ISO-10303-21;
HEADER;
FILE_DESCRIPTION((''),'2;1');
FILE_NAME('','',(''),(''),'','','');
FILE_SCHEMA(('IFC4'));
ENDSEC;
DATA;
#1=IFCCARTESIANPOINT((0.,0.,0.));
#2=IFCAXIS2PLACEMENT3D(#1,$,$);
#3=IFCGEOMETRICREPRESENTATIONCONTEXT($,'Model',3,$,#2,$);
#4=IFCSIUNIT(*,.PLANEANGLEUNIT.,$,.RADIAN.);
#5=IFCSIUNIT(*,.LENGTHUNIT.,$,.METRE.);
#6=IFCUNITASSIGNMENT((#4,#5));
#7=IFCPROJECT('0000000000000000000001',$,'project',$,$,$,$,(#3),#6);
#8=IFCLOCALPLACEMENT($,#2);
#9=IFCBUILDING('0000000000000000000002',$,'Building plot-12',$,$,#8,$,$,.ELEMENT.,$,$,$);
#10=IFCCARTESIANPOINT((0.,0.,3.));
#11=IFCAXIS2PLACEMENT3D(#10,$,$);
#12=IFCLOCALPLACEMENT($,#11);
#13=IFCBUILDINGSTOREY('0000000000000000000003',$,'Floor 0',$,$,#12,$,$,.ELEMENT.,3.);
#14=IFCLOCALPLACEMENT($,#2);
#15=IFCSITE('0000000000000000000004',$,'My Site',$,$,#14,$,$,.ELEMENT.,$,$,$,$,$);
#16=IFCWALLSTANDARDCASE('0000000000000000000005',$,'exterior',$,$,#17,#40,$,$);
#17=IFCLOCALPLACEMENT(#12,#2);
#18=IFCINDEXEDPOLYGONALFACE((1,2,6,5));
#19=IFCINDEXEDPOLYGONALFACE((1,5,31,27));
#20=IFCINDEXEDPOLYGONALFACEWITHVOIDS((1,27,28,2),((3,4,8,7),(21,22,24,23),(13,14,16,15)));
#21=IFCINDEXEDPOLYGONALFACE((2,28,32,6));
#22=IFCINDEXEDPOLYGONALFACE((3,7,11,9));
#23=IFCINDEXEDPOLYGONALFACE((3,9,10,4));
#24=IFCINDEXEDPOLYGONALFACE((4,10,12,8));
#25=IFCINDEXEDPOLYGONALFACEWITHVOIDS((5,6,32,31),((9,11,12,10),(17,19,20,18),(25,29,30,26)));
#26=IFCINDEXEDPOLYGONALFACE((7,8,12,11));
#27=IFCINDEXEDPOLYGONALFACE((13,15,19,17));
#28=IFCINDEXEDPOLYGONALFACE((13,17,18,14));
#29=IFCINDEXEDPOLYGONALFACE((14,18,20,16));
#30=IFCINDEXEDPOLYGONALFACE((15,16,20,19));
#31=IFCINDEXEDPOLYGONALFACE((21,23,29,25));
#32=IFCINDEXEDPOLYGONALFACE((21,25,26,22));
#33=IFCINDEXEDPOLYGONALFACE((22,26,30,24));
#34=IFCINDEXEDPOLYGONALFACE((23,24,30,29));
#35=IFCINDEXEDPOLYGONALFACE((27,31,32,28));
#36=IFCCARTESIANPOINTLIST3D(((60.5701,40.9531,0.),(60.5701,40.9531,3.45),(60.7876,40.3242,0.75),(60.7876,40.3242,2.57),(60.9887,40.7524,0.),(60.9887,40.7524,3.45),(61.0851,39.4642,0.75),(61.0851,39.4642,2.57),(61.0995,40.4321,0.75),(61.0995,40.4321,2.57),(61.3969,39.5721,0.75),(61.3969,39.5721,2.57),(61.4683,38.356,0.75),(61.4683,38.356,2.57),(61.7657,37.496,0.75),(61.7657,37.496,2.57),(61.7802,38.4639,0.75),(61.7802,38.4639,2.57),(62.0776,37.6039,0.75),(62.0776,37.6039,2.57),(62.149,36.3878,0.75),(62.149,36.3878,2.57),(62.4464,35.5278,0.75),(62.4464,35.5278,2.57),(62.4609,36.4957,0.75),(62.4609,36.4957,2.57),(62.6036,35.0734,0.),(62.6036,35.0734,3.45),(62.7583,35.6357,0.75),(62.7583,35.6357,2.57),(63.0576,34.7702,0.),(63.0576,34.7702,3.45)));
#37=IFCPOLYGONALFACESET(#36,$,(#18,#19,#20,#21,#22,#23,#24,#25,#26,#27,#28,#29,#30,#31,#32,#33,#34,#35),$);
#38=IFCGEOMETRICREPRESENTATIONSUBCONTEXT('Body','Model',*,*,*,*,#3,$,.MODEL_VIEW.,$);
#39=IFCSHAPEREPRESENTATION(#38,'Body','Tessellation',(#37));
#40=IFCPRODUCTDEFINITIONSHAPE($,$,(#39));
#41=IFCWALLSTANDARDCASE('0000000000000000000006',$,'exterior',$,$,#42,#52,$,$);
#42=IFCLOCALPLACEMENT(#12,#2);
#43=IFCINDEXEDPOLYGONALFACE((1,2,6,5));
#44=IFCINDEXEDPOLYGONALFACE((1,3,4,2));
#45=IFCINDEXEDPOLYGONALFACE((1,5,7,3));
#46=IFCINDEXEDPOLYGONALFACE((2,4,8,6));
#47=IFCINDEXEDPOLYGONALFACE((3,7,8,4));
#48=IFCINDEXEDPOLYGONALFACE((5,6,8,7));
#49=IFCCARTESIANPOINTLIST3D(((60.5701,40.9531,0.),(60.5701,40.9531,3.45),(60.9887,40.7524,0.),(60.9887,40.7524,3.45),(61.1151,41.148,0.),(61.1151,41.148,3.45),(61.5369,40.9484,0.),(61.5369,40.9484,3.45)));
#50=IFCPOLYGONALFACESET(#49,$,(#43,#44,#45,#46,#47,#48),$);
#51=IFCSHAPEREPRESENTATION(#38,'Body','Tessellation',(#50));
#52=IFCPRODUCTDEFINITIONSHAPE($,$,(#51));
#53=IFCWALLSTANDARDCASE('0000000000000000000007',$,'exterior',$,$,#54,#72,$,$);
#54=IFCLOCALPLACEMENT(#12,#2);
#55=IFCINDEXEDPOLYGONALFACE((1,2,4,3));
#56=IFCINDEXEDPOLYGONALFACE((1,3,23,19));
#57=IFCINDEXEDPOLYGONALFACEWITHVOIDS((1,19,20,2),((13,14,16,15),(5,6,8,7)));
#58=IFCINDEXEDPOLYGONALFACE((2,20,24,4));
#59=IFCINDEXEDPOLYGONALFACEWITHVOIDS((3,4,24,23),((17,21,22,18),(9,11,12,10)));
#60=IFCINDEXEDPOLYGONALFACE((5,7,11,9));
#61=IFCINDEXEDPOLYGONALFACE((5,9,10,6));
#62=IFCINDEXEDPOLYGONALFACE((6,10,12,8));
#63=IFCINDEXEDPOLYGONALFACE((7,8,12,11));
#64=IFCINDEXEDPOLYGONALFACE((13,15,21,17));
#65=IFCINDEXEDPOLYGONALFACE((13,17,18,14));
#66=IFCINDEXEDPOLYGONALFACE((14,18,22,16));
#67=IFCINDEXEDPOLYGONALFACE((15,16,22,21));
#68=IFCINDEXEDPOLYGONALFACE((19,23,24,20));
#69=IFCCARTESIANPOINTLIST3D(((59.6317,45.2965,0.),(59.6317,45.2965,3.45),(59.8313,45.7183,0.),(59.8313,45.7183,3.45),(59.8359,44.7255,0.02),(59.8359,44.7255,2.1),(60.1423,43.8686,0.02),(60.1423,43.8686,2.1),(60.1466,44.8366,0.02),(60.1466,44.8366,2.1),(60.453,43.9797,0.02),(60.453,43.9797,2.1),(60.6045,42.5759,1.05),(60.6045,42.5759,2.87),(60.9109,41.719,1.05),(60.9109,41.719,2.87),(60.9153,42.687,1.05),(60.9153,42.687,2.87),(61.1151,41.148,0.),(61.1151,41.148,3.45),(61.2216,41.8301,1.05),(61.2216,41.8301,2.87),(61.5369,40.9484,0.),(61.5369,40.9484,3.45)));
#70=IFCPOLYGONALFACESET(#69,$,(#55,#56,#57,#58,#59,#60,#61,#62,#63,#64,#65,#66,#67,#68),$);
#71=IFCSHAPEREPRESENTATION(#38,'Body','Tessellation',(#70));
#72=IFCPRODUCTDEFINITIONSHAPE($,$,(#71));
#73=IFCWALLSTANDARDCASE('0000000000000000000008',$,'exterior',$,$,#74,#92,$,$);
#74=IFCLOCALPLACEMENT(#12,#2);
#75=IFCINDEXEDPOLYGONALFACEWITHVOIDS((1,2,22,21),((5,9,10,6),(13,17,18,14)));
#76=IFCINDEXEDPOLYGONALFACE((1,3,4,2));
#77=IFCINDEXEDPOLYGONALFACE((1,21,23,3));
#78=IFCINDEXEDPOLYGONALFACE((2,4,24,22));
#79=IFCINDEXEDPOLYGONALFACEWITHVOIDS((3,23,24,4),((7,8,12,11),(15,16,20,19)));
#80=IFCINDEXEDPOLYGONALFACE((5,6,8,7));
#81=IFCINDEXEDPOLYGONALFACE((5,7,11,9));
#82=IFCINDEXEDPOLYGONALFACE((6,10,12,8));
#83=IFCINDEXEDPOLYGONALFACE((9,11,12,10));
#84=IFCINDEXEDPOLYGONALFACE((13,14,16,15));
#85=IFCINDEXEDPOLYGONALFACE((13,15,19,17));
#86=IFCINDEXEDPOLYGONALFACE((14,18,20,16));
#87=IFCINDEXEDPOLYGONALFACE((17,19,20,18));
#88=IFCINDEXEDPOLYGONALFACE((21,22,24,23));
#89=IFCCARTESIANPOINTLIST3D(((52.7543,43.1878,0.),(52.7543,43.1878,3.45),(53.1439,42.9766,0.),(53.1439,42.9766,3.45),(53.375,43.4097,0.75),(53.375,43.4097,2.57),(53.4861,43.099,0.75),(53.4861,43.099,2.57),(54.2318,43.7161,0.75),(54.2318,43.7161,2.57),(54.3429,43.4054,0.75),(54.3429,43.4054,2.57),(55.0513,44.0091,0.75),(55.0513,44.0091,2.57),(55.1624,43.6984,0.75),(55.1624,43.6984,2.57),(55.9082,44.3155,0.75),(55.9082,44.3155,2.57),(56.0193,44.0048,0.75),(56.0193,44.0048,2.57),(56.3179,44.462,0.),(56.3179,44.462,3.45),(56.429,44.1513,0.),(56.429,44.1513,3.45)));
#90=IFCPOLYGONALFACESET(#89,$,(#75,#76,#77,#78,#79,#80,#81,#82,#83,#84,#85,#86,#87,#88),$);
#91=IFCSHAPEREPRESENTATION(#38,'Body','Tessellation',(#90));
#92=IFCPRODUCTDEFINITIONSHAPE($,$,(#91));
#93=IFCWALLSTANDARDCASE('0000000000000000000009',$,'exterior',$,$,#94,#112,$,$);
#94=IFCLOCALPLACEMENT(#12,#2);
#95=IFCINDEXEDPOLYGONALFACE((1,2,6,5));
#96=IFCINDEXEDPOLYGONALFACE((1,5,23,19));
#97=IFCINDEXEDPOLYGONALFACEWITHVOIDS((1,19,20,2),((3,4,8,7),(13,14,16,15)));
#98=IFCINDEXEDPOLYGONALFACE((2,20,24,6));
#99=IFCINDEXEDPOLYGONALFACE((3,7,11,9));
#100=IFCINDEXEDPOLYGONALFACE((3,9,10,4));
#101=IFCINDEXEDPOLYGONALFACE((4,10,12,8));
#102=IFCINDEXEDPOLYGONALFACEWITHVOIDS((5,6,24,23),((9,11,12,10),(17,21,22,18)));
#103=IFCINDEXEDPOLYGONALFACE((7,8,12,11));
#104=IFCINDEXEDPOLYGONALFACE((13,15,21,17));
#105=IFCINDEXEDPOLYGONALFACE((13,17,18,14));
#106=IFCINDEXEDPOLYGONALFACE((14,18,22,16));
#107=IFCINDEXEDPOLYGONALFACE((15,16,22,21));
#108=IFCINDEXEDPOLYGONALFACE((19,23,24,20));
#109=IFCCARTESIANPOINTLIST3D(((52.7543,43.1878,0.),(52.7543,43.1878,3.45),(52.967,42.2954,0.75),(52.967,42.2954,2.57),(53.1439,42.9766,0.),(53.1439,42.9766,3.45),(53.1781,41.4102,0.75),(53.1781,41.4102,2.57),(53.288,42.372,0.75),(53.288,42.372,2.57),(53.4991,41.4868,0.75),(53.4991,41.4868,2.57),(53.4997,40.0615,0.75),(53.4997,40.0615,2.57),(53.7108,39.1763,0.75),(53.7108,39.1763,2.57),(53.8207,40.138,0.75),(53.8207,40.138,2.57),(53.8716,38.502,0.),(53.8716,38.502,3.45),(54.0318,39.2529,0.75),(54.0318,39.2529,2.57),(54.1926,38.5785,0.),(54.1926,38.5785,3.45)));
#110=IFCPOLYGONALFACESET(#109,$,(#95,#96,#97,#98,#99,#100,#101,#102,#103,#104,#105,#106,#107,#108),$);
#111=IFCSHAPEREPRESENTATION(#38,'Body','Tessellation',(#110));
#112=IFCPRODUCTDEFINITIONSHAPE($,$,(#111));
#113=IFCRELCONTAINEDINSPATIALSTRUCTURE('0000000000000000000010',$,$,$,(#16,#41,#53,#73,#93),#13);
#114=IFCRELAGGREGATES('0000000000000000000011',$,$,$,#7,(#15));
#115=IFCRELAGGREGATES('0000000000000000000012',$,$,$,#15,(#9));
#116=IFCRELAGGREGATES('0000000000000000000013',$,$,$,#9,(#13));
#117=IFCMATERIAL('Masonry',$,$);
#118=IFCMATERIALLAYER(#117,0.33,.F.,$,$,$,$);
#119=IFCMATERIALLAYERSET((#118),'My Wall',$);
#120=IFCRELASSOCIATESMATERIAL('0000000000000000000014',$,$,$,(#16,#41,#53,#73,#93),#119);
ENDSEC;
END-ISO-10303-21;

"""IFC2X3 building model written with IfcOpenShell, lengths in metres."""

from ifc_helpers import new_model, si_unit, frame, origin, place, context, subcontext, project, spatial, polyline, outline, extrude, material, layer, layer_set, layer_usage, element, save


model = new_model("IFC2X3")

# Units and contexts
model_context = context("Model", 3, world=origin())
body_context = subcontext(model_context, "Body", "Model", "MODEL_VIEW")
ifc_project = project(units=[si_unit("PLANEANGLEUNIT", "RADIAN"), si_unit("LENGTHUNIT", "METRE")], contexts=[model_context])

# Site, building, storey
site_placement = place(None, origin())
site = spatial("IfcSite", under=ifc_project, at=site_placement, Name="My Site", CompositionType="ELEMENT")
building_placement = place(None, origin())
building = spatial("IfcBuilding", under=site, at=building_placement, Name="Building plot-12", CompositionType="ELEMENT")
storey_placement = place(None, frame((0.0, 0.0, 3.0)))
storey = spatial("IfcBuildingStorey", under=building, at=storey_placement, Name="Floor 0", CompositionType="ELEMENT", Elevation=3.0)

# Shared definitions
ifc_material = material(Name="Masonry")
ifc_layer = layer(ifc_material, 0.33, ventilated=False)
ifc_layer_set = layer_set([ifc_layer], Name="My Wall")
ifc_layer_usage = layer_usage(ifc_layer_set, "AXIS2", "NEGATIVE", 0.08)

# Wall, openings
wall_1_placement = place(storey_placement, origin())
wall_1 = element("IfcWallStandardCase", 1, at=wall_1_placement, inside=storey, material=ifc_layer_usage, Name="exterior", context=body_context, shape_type="SweptSolid", body=[
    extrude(outline(polyline([(62.6036, 35.0734), (63.0576, 34.7702), (60.9887, 40.7524), (60.5701, 40.9531), (62.6036, 35.0734)])), origin(), (0.0, 0.0, 1.0), 3.45),
])
opening_1_placement = place(storey_placement, frame((0.0, 0.0, 0.75)))
element("IfcOpeningElement", 2, at=opening_1_placement, cuts=wall_1, ObjectType="Opening", context=body_context, shape_type="SweptSolid", body=[
    extrude(outline(polyline([(62.7583, 35.6357), (62.4609, 36.4957), (62.149, 36.3878), (62.4464, 35.5278), (62.7583, 35.6357)])), origin(), (0.0, 0.0, 1.0), 1.82),
])
opening_2_placement = place(storey_placement, frame((0.0, 0.0, 0.75)))
element("IfcOpeningElement", 3, at=opening_2_placement, cuts=wall_1, ObjectType="Opening", context=body_context, shape_type="SweptSolid", body=[
    extrude(outline(polyline([(62.0776, 37.6039), (61.7802, 38.4639), (61.4683, 38.356), (61.7657, 37.496), (62.0776, 37.6039)])), origin(), (0.0, 0.0, 1.0), 1.82),
])
opening_3_placement = place(storey_placement, frame((0.0, 0.0, 0.75)))
element("IfcOpeningElement", 4, at=opening_3_placement, cuts=wall_1, ObjectType="Opening", context=body_context, shape_type="SweptSolid", body=[
    extrude(outline(polyline([(61.3969, 39.5721), (61.0995, 40.4321), (60.7876, 40.3242), (61.0851, 39.4642), (61.3969, 39.5721)])), origin(), (0.0, 0.0, 1.0), 1.82),
])

# Wall
wall_2_placement = place(storey_placement, origin())
element("IfcWallStandardCase", 5, at=wall_2_placement, inside=storey, material=ifc_layer_usage, Name="exterior", context=body_context, shape_type="SweptSolid", body=[
    extrude(outline(polyline([(60.5701, 40.9531), (60.9887, 40.7524), (61.5369, 40.9484), (61.1151, 41.148), (60.5701, 40.9531)])), origin(), (0.0, 0.0, 1.0), 3.45),
])

# Walls, openings
wall_3_placement = place(storey_placement, origin())
wall_3 = element("IfcWallStandardCase", 6, at=wall_3_placement, inside=storey, material=ifc_layer_usage, Name="exterior", context=body_context, shape_type="SweptSolid", body=[
    extrude(outline(polyline([(61.1151, 41.148), (61.5369, 40.9484), (59.8313, 45.7183), (59.6317, 45.2965), (61.1151, 41.148)])), origin(), (0.0, 0.0, 1.0), 3.45),
])
opening_4_placement = place(storey_placement, frame((0.0, 0.0, 1.05)))
element("IfcOpeningElement", 7, at=opening_4_placement, cuts=wall_3, ObjectType="Opening", context=body_context, shape_type="SweptSolid", body=[
    extrude(outline(polyline([(61.2216, 41.8301), (60.9153, 42.687), (60.6045, 42.5759), (60.9109, 41.719), (61.2216, 41.8301)])), origin(), (0.0, 0.0, 1.0), 1.82),
])
opening_5_placement = place(storey_placement, frame((0.0, 0.0, 0.02)))
element("IfcOpeningElement", 8, at=opening_5_placement, cuts=wall_3, ObjectType="Opening", context=body_context, shape_type="SweptSolid", body=[
    extrude(outline(polyline([(60.453, 43.9797), (60.1466, 44.8366), (59.8359, 44.7255), (60.1423, 43.8686), (60.453, 43.9797)])), origin(), (0.0, 0.0, 1.0), 2.08),
])
wall_4_placement = place(storey_placement, origin())
wall_4 = element("IfcWallStandardCase", 9, at=wall_4_placement, inside=storey, material=ifc_layer_usage, Name="exterior", context=body_context, shape_type="SweptSolid", body=[
    extrude(outline(polyline([(56.429, 44.1513), (56.3179, 44.462), (52.7543, 43.1878), (53.1439, 42.9766), (56.429, 44.1513)])), origin(), (0.0, 0.0, 1.0), 3.45),
])
opening_6_placement = place(storey_placement, frame((0.0, 0.0, 0.75)))
element("IfcOpeningElement", 10, at=opening_6_placement, cuts=wall_4, ObjectType="Opening", context=body_context, shape_type="SweptSolid", body=[
    extrude(outline(polyline([(55.9082, 44.3155), (55.0513, 44.0091), (55.1624, 43.6984), (56.0193, 44.0048), (55.9082, 44.3155)])), origin(), (0.0, 0.0, 1.0), 1.82),
])
opening_7_placement = place(storey_placement, frame((0.0, 0.0, 0.75)))
element("IfcOpeningElement", 11, at=opening_7_placement, cuts=wall_4, ObjectType="Opening", context=body_context, shape_type="SweptSolid", body=[
    extrude(outline(polyline([(54.2318, 43.7161), (53.375, 43.4097), (53.4861, 43.099), (54.3429, 43.4054), (54.2318, 43.7161)])), origin(), (0.0, 0.0, 1.0), 1.82),
])
wall_5_placement = place(storey_placement, origin())
wall_5 = element("IfcWallStandardCase", 12, at=wall_5_placement, inside=storey, material=ifc_layer_usage, Name="exterior", context=body_context, shape_type="SweptSolid", body=[
    extrude(outline(polyline([(53.1439, 42.9766), (52.7543, 43.1878), (53.8716, 38.502), (54.1926, 38.5785), (53.1439, 42.9766)])), origin(), (0.0, 0.0, 1.0), 3.45),
])
opening_8_placement = place(storey_placement, frame((0.0, 0.0, 0.75)))
element("IfcOpeningElement", 13, at=opening_8_placement, cuts=wall_5, ObjectType="Opening", context=body_context, shape_type="SweptSolid", body=[
    extrude(outline(polyline([(52.967, 42.2954), (53.1781, 41.4102), (53.4991, 41.4868), (53.288, 42.372), (52.967, 42.2954)])), origin(), (0.0, 0.0, 1.0), 1.82),
])
opening_9_placement = place(storey_placement, frame((0.0, 0.0, 0.75)))
element("IfcOpeningElement", 14, at=opening_9_placement, cuts=wall_5, ObjectType="Opening", context=body_context, shape_type="SweptSolid", body=[
    extrude(outline(polyline([(53.4997, 40.0615), (53.7108, 39.1763), (54.0318, 39.2529), (53.8207, 40.138), (53.4997, 40.0615)])), origin(), (0.0, 0.0, 1.0), 1.82),
])

save(model, "model.ifc")
